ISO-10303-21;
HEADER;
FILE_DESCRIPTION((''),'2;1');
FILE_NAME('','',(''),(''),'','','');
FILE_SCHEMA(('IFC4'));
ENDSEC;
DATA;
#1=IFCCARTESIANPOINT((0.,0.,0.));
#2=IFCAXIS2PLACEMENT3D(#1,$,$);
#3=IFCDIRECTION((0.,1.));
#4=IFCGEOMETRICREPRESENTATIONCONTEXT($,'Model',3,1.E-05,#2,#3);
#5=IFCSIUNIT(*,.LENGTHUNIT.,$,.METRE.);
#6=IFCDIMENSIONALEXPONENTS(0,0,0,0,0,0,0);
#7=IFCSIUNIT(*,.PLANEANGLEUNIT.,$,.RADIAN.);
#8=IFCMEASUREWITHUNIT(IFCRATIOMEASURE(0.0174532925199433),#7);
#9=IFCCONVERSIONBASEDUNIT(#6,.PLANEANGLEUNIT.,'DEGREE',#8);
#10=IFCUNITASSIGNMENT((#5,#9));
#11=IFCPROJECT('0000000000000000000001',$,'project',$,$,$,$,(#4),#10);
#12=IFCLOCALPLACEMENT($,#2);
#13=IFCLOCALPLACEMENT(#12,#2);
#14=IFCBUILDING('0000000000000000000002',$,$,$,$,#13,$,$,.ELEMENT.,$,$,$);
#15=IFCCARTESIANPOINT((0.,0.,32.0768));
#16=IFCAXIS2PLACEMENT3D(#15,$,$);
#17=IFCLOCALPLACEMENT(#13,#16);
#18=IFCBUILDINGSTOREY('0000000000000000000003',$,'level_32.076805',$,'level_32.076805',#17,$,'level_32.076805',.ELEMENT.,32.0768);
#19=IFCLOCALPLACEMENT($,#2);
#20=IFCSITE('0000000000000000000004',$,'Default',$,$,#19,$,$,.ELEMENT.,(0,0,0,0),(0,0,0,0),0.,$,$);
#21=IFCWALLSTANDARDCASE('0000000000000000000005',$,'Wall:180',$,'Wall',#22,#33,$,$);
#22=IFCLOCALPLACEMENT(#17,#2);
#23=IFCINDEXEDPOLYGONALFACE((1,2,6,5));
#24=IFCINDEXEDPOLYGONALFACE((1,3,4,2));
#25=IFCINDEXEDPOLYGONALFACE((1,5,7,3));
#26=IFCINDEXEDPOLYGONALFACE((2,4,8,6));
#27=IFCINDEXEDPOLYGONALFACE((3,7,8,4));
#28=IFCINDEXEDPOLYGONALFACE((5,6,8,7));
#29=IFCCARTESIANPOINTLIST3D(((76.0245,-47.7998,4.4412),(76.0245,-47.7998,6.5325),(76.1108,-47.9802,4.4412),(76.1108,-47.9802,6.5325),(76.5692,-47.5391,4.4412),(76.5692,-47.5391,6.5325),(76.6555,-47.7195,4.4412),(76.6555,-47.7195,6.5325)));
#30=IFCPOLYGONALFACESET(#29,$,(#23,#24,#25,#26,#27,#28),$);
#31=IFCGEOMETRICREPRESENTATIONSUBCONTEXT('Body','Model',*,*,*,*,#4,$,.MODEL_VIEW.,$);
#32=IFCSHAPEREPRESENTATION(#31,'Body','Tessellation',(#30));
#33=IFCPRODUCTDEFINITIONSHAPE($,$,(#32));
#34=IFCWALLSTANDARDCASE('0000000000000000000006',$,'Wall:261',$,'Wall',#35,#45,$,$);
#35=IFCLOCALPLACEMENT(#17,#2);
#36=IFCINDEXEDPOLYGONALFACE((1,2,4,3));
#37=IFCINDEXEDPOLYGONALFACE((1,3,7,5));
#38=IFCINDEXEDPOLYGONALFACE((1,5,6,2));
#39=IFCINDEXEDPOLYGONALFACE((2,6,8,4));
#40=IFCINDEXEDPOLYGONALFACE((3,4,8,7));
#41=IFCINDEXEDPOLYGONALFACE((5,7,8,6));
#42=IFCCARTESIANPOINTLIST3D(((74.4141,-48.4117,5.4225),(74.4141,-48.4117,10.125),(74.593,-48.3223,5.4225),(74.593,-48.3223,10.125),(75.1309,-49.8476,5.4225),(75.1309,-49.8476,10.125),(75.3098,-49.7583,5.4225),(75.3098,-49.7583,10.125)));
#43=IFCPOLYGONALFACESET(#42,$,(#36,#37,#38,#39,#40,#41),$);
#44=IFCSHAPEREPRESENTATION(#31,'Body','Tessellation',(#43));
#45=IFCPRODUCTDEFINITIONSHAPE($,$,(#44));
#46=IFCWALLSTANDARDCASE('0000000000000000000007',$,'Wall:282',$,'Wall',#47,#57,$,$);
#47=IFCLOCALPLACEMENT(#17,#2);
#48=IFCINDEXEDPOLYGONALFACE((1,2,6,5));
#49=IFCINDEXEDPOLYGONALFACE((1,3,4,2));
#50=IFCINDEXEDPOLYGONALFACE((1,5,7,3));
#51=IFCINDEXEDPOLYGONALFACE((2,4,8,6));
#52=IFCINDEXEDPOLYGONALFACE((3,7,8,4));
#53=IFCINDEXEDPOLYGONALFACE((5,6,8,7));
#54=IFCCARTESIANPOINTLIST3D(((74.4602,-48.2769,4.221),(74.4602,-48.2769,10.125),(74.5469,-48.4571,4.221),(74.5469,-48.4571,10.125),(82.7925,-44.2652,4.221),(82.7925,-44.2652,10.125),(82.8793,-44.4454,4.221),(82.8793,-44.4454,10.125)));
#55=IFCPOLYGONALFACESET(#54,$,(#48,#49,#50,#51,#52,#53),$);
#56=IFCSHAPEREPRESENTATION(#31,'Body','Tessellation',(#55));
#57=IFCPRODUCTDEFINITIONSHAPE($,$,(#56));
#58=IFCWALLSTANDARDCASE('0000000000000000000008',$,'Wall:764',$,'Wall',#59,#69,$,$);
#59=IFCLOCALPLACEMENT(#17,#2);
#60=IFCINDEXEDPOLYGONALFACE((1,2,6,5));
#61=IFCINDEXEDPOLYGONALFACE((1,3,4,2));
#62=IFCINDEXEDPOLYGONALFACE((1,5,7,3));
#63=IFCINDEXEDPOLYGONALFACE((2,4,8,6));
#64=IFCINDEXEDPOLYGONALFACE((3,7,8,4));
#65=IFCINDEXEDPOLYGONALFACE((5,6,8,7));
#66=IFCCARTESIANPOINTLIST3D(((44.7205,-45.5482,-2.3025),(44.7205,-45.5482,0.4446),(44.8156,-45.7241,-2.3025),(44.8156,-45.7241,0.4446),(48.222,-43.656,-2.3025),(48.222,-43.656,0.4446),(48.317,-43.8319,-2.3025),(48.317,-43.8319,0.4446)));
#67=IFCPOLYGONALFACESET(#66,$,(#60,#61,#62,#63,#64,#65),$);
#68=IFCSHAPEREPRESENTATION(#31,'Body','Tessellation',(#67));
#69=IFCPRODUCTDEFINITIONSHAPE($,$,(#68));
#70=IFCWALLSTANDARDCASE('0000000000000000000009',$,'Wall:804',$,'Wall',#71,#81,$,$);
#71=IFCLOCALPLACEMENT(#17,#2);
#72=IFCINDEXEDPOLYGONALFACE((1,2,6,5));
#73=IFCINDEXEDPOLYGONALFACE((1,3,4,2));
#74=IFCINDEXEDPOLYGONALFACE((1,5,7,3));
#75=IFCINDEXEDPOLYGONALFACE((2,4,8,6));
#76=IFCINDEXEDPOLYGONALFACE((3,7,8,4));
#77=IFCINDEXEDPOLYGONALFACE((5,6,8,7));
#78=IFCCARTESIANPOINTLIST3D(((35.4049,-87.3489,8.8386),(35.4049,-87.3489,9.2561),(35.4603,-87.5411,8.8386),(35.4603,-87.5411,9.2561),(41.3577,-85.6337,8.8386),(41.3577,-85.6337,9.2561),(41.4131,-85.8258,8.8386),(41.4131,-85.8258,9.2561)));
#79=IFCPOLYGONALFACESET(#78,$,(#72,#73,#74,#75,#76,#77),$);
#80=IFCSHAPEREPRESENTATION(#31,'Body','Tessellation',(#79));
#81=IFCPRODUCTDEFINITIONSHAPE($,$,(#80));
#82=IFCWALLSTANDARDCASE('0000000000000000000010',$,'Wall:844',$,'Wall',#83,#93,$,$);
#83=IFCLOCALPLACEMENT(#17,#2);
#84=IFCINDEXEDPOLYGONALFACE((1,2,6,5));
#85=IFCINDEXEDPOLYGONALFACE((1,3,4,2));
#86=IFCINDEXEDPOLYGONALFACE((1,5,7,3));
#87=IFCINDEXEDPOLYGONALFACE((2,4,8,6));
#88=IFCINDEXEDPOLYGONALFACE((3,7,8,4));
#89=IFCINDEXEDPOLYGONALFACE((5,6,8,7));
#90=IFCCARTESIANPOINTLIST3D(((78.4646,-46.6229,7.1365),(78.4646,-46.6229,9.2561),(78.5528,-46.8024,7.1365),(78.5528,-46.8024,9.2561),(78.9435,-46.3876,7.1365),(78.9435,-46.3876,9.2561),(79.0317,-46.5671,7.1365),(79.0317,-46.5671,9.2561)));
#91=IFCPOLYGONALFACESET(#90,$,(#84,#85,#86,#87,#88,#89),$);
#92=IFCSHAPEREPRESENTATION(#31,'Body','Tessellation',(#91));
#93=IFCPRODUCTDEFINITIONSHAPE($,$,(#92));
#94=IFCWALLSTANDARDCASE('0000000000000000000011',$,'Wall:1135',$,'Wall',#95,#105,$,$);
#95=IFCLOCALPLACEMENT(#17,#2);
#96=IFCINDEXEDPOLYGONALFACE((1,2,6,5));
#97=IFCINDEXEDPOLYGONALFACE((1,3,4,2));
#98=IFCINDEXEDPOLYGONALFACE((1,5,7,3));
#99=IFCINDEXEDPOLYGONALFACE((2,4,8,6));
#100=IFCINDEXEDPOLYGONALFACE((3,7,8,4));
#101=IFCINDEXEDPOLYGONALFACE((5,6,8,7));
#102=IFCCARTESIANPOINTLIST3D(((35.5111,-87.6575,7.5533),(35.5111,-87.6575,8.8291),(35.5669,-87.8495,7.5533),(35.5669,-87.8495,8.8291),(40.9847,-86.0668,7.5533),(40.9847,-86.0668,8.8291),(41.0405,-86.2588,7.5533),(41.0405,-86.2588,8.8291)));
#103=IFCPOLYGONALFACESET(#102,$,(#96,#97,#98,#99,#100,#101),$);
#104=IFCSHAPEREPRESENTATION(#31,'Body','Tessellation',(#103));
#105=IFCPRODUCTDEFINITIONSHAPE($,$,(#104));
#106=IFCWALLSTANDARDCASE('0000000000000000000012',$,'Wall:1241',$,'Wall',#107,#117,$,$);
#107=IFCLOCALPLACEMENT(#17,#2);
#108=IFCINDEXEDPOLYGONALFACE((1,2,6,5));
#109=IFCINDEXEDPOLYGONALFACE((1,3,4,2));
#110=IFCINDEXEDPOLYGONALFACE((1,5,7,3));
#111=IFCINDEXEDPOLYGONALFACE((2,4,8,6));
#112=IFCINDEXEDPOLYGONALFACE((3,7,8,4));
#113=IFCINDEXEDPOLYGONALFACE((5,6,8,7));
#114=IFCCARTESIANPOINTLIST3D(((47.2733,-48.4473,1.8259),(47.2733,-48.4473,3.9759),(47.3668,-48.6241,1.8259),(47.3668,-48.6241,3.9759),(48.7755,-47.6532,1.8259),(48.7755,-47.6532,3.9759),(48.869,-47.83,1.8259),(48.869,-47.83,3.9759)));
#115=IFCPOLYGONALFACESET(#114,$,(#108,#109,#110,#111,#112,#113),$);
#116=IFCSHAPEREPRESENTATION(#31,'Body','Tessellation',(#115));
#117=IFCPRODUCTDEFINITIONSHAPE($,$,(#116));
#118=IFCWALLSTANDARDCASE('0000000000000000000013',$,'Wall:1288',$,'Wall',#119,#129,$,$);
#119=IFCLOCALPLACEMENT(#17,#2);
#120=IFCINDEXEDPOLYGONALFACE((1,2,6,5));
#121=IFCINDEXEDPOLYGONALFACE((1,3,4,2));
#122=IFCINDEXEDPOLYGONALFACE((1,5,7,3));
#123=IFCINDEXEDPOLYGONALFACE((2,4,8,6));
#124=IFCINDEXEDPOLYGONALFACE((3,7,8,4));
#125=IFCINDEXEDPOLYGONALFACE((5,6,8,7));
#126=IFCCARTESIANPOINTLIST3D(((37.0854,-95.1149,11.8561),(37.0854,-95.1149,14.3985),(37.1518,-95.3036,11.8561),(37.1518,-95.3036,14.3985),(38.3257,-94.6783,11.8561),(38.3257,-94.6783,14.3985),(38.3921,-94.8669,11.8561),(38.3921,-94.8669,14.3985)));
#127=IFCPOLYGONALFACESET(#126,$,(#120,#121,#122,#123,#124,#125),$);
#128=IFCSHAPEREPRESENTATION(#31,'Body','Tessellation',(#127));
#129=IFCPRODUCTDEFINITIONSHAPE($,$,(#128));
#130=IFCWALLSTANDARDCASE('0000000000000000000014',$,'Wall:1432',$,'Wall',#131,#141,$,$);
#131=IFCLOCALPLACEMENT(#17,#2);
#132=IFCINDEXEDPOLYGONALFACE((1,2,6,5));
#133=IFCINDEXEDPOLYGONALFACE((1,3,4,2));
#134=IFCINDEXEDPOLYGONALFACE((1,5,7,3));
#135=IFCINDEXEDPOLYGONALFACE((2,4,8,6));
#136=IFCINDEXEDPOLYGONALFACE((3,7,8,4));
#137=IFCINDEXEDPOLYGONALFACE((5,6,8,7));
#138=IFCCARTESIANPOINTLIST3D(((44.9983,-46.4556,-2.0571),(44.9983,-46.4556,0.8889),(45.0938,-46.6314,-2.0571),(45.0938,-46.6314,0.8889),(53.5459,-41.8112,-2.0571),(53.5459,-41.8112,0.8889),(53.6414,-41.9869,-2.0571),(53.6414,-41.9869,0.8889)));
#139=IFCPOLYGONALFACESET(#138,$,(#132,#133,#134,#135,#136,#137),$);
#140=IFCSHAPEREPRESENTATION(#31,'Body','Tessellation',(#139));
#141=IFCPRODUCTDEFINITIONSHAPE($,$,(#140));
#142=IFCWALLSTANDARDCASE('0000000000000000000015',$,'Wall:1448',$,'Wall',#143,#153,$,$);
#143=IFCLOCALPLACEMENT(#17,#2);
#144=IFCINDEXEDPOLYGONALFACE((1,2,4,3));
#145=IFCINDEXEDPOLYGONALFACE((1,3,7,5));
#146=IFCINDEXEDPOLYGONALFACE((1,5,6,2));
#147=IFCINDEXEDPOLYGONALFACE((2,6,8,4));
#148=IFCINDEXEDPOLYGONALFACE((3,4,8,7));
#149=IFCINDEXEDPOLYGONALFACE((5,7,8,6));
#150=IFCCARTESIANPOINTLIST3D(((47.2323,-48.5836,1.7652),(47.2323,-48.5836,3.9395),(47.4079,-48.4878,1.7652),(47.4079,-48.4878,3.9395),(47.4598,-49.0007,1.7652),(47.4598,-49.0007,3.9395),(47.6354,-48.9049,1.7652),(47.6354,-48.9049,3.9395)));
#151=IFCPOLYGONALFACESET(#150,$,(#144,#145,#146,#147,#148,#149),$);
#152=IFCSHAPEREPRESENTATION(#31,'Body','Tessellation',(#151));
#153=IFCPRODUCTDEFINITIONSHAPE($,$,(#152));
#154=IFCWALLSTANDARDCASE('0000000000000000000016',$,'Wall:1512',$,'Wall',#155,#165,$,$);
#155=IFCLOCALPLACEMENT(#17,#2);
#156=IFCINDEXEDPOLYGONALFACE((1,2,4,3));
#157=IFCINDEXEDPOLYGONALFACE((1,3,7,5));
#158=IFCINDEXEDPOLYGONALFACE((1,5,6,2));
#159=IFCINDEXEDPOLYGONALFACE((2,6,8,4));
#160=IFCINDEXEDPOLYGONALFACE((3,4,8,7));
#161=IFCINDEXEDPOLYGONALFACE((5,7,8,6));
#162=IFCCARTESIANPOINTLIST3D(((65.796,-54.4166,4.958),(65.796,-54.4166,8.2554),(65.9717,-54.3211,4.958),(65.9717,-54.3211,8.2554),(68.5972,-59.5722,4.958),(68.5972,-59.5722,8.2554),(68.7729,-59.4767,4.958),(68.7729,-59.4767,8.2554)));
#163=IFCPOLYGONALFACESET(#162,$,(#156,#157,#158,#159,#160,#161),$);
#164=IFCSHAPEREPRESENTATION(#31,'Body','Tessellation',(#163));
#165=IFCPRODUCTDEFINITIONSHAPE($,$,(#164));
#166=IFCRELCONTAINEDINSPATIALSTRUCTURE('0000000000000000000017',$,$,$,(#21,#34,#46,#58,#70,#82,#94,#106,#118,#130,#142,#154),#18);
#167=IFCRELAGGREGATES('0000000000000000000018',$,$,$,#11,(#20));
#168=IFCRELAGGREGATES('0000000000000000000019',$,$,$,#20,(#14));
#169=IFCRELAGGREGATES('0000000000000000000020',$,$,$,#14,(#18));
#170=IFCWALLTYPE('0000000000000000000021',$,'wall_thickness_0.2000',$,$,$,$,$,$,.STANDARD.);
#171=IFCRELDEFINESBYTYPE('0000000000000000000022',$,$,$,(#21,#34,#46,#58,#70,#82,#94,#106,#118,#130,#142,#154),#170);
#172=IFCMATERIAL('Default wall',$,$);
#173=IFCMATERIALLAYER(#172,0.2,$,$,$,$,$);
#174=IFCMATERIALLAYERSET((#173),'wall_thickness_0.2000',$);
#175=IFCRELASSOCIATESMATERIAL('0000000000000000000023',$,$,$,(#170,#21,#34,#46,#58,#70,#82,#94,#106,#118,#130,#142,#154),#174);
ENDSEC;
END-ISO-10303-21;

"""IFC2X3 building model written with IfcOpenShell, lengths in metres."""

from ifc_helpers import new_model, entity, si_unit, converted_unit, direction, frame, origin, place, context, subcontext, project, spatial, polyline, outline, extrude, material, layer, layer_set, layer_usage, type_object, element, save


model = new_model("IFC2X3")

# Units and contexts
model_context = context("Model", 3, precision=1e-05, world=origin(), true_north=direction((0.0, 1.0)))
body_context = subcontext(model_context, "Body", "Model", "MODEL_VIEW")
ifc_project = project(units=[si_unit("LENGTHUNIT", "METRE"), converted_unit("PLANEANGLEUNIT", "DEGREE", entity("IfcRatioMeasure", 0.0174532925199433), si_unit("PLANEANGLEUNIT", "RADIAN"), dimensions=[0, 0, 0, 0, 0, 0, 0])], contexts=[model_context])

# Site, building, storey
site_placement = place(None, origin())
site = spatial("IfcSite", under=ifc_project, at=site_placement, Name="Default", CompositionType="ELEMENT", RefLatitude=(0, 0, 0, 0), RefLongitude=(0, 0, 0, 0), RefElevation=0.0)
placement_1 = place(None, origin())
building_placement = place(placement_1, origin())
building = spatial("IfcBuilding", under=site, at=building_placement, CompositionType="ELEMENT")
storey_placement = place(building_placement, frame((0.0, 0.0, 32.0768)))
storey = spatial("IfcBuildingStorey", under=building, at=storey_placement, Name="level_32.076805", ObjectType="level_32.076805", LongName="level_32.076805", CompositionType="ELEMENT", Elevation=32.0768)

# Walls
ifc_material_1 = material(Name="Default wall")
ifc_layer = layer(ifc_material_1, 0.2)
ifc_layer_set = layer_set([ifc_layer], Name="wall_thickness_0.2000")
ifc_layer_usage = layer_usage(ifc_layer_set, "AXIS2", "POSITIVE", -0.1)
wall_type = type_object("IfcWallType", Name="wall_thickness_0.2000", PredefinedType="STANDARD", material=ifc_layer_set)
placement_2 = place(building_placement, frame((0.0, 0.0, 36.518)))
wall_1_placement = place(placement_2, frame((76.0676, -47.89, 0.0), z_axis=(0.0, 0.0, 1.0), x_axis=(0.902013, 0.431709, 0.0)))
element("IfcWallStandardCase", 1, at=wall_1_placement, inside=storey, type_object=wall_type, material=ifc_layer_usage, Name="Wall:180", ObjectType="Wall", context=body_context, shape_type="SweptSolid", body=[
    extrude(outline(polyline([(0.6039, -0.1), (0.6039, 0.1), (0.0, 0.1), (0.0, -0.1), (0.6039, -0.1)])), origin(), (0.0, 0.0, 1.0), 2.0913),
])
placement_3 = place(building_placement, frame((0.0, 0.0, 37.4993)))
wall_2_placement = place(placement_3, frame((75.2204, -49.8029, 0.0), z_axis=(0.0, 0.0, 1.0), x_axis=(-0.446635, 0.894716, 0.0)))
element("IfcWallStandardCase", 2, at=wall_2_placement, inside=storey, type_object=wall_type, material=ifc_layer_usage, Name="Wall:261", ObjectType="Wall", context=body_context, shape_type="SweptSolid", body=[
    extrude(outline(polyline([(1.6049, -0.1), (1.6049, 0.1), (0.0, 0.1), (0.0, -0.1), (1.6049, -0.1)])), origin(), (0.0, 0.0, 1.0), 4.7025),
])
placement_4 = place(building_placement, frame((0.0, 0.0, 36.2978)))
wall_3_placement = place(placement_4, frame((74.5036, -48.367, 0.0), z_axis=(0.0, 0.0, 1.0), x_axis=(0.90101, 0.433798, 0.0)))
element("IfcWallStandardCase", 3, at=wall_3_placement, inside=storey, type_object=wall_type, material=ifc_layer_usage, Name="Wall:282", ObjectType="Wall", context=body_context, shape_type="SweptSolid", body=[
    extrude(outline(polyline([(9.2478, -0.1), (9.2478, 0.1), (0.0, 0.1), (0.0, -0.1), (9.2478, -0.1)])), origin(), (0.0, 0.0, 1.0), 5.9039),
])
placement_5 = place(building_placement, frame((0.0, 0.0, 29.7743)))
wall_4_placement = place(placement_5, frame((44.7681, -45.6361, 0.0), z_axis=(0.0, 0.0, 1.0), x_axis=(0.879755, 0.475428, 0.0)))
element("IfcWallStandardCase", 4, at=wall_4_placement, inside=storey, type_object=wall_type, material=ifc_layer_usage, Name="Wall:764", ObjectType="Wall", context=body_context, shape_type="SweptSolid", body=[
    extrude(outline(polyline([(3.98, -0.1), (3.98, 0.1), (0.0, 0.1), (0.0, -0.1), (3.98, -0.1)])), origin(), (0.0, 0.0, 1.0), 2.7471),
])
placement_6 = place(building_placement, frame((0.0, 0.0, 40.9154)))
wall_5_placement = place(placement_6, frame((35.4326, -87.445, 0.0), z_axis=(0.0, 0.0, 1.0), x_axis=(0.960906, 0.276875, 0.0)))
element("IfcWallStandardCase", 5, at=wall_5_placement, inside=storey, type_object=wall_type, material=ifc_layer_usage, Name="Wall:804", ObjectType="Wall", context=body_context, shape_type="SweptSolid", body=[
    extrude(outline(polyline([(6.195, -0.1), (6.195, 0.1), (0.0, 0.1), (0.0, -0.1), (6.195, -0.1)])), origin(), (0.0, 0.0, 1.0), 0.4175),
])
placement_7 = place(building_placement, frame((0.0, 0.0, 39.2133)))
wall_6_placement = place(placement_7, frame((78.5087, -46.7127, 0.0), z_axis=(0.0, 0.0, 1.0), x_axis=(0.897466, 0.441084, 0.0)))
element("IfcWallStandardCase", 6, at=wall_6_placement, inside=storey, type_object=wall_type, material=ifc_layer_usage, Name="Wall:844", ObjectType="Wall", context=body_context, shape_type="SweptSolid", body=[
    extrude(outline(polyline([(0.5336, -0.1), (0.5336, 0.1), (0.0, 0.1), (0.0, -0.1), (0.5336, -0.1)])), origin(), (0.0, 0.0, 1.0), 2.1195),
])
placement_8 = place(building_placement, frame((0.0, 0.0, 39.6301)))
wall_7_placement = place(placement_8, frame((35.539, -87.7535, 0.0), z_axis=(0.0, 0.0, 1.0), x_axis=(0.96027, 0.279072, 0.0)))
element("IfcWallStandardCase", 7, at=wall_7_placement, inside=storey, type_object=wall_type, material=ifc_layer_usage, Name="Wall:1135", ObjectType="Wall", context=body_context, shape_type="SweptSolid", body=[
    extrude(outline(polyline([(5.7, -0.1), (5.7, 0.1), (0.0, 0.1), (0.0, -0.1), (5.7, -0.1)])), origin(), (0.0, 0.0, 1.0), 1.2758),
])
placement_9 = place(building_placement, frame((0.0, 0.0, 33.9027)))
wall_8_placement = place(placement_9, frame((48.8223, -47.7416, 0.0), z_axis=(0.0, 0.0, 1.0), x_axis=(-0.884088, -0.46732, 0.0)))
element("IfcWallStandardCase", 8, at=wall_8_placement, inside=storey, type_object=wall_type, material=ifc_layer_usage, Name="Wall:1241", ObjectType="Wall", context=body_context, shape_type="SweptSolid", body=[
    extrude(outline(polyline([(1.6991, -0.1), (1.6991, 0.1), (0.0, 0.1), (0.0, -0.1), (1.6991, -0.1)])), origin(), (0.0, 0.0, 1.0), 2.15),
])
placement_10 = place(building_placement, frame((0.0, 0.0, 43.9329)))
wall_9_placement = place(placement_10, frame((37.1186, -95.2093, 0.0), z_axis=(0.0, 0.0, 1.0), x_axis=(0.94325, 0.332084, 0.0)))
element("IfcWallStandardCase", 9, at=wall_9_placement, inside=storey, type_object=wall_type, material=ifc_layer_usage, Name="Wall:1288", ObjectType="Wall", context=body_context, shape_type="SweptSolid", body=[
    extrude(outline(polyline([(1.315, -0.1), (1.315, 0.1), (0.0, 0.1), (0.0, -0.1), (1.315, -0.1)])), origin(), (0.0, 0.0, 1.0), 2.5424),
])
placement_11 = place(building_placement, frame((0.0, 0.0, 30.0197)))
wall_10_placement = place(placement_11, frame((45.0461, -46.5435, 0.0), z_axis=(0.0, 0.0, 1.0), x_axis=(0.878665, 0.477438, 0.0)))
element("IfcWallStandardCase", 10, at=wall_10_placement, inside=storey, type_object=wall_type, material=ifc_layer_usage, Name="Wall:1432", ObjectType="Wall", context=body_context, shape_type="SweptSolid", body=[
    extrude(outline(polyline([(9.7279, -0.1), (9.7279, 0.1), (0.0, 0.1), (0.0, -0.1), (9.7279, -0.1)])), origin(), (0.0, 0.0, 1.0), 2.946),
])
placement_12 = place(building_placement, frame((0.0, 0.0, 33.842)))
wall_11_placement = place(placement_12, frame((47.5476, -48.9528, 0.0), z_axis=(0.0, 0.0, 1.0), x_axis=(-0.478855, 0.877894, 0.0)))
element("IfcWallStandardCase", 11, at=wall_11_placement, inside=storey, type_object=wall_type, material=ifc_layer_usage, Name="Wall:1448", ObjectType="Wall", context=body_context, shape_type="SweptSolid", body=[
    extrude(outline(polyline([(0.4751, -0.1), (0.4751, 0.1), (0.0, 0.1), (0.0, -0.1), (0.4751, -0.1)])), origin(), (0.0, 0.0, 1.0), 2.1743),
])
placement_13 = place(building_placement, frame((0.0, 0.0, 37.0348)))
wall_12_placement = place(placement_13, frame((65.8838, -54.3688, 0.0), z_axis=(0.0, 0.0, 1.0), x_axis=(0.477407, -0.878682, 0.0)))
element("IfcWallStandardCase", 12, at=wall_12_placement, inside=storey, type_object=wall_type, material=ifc_layer_usage, Name="Wall:1512", ObjectType="Wall", context=body_context, shape_type="SweptSolid", body=[
    extrude(outline(polyline([(5.8675, -0.1), (5.8675, 0.1), (0.0, 0.1), (0.0, -0.1), (5.8675, -0.1)])), origin(), (0.0, 0.0, 1.0), 3.2974),
])

save(model, "model.ifc")
